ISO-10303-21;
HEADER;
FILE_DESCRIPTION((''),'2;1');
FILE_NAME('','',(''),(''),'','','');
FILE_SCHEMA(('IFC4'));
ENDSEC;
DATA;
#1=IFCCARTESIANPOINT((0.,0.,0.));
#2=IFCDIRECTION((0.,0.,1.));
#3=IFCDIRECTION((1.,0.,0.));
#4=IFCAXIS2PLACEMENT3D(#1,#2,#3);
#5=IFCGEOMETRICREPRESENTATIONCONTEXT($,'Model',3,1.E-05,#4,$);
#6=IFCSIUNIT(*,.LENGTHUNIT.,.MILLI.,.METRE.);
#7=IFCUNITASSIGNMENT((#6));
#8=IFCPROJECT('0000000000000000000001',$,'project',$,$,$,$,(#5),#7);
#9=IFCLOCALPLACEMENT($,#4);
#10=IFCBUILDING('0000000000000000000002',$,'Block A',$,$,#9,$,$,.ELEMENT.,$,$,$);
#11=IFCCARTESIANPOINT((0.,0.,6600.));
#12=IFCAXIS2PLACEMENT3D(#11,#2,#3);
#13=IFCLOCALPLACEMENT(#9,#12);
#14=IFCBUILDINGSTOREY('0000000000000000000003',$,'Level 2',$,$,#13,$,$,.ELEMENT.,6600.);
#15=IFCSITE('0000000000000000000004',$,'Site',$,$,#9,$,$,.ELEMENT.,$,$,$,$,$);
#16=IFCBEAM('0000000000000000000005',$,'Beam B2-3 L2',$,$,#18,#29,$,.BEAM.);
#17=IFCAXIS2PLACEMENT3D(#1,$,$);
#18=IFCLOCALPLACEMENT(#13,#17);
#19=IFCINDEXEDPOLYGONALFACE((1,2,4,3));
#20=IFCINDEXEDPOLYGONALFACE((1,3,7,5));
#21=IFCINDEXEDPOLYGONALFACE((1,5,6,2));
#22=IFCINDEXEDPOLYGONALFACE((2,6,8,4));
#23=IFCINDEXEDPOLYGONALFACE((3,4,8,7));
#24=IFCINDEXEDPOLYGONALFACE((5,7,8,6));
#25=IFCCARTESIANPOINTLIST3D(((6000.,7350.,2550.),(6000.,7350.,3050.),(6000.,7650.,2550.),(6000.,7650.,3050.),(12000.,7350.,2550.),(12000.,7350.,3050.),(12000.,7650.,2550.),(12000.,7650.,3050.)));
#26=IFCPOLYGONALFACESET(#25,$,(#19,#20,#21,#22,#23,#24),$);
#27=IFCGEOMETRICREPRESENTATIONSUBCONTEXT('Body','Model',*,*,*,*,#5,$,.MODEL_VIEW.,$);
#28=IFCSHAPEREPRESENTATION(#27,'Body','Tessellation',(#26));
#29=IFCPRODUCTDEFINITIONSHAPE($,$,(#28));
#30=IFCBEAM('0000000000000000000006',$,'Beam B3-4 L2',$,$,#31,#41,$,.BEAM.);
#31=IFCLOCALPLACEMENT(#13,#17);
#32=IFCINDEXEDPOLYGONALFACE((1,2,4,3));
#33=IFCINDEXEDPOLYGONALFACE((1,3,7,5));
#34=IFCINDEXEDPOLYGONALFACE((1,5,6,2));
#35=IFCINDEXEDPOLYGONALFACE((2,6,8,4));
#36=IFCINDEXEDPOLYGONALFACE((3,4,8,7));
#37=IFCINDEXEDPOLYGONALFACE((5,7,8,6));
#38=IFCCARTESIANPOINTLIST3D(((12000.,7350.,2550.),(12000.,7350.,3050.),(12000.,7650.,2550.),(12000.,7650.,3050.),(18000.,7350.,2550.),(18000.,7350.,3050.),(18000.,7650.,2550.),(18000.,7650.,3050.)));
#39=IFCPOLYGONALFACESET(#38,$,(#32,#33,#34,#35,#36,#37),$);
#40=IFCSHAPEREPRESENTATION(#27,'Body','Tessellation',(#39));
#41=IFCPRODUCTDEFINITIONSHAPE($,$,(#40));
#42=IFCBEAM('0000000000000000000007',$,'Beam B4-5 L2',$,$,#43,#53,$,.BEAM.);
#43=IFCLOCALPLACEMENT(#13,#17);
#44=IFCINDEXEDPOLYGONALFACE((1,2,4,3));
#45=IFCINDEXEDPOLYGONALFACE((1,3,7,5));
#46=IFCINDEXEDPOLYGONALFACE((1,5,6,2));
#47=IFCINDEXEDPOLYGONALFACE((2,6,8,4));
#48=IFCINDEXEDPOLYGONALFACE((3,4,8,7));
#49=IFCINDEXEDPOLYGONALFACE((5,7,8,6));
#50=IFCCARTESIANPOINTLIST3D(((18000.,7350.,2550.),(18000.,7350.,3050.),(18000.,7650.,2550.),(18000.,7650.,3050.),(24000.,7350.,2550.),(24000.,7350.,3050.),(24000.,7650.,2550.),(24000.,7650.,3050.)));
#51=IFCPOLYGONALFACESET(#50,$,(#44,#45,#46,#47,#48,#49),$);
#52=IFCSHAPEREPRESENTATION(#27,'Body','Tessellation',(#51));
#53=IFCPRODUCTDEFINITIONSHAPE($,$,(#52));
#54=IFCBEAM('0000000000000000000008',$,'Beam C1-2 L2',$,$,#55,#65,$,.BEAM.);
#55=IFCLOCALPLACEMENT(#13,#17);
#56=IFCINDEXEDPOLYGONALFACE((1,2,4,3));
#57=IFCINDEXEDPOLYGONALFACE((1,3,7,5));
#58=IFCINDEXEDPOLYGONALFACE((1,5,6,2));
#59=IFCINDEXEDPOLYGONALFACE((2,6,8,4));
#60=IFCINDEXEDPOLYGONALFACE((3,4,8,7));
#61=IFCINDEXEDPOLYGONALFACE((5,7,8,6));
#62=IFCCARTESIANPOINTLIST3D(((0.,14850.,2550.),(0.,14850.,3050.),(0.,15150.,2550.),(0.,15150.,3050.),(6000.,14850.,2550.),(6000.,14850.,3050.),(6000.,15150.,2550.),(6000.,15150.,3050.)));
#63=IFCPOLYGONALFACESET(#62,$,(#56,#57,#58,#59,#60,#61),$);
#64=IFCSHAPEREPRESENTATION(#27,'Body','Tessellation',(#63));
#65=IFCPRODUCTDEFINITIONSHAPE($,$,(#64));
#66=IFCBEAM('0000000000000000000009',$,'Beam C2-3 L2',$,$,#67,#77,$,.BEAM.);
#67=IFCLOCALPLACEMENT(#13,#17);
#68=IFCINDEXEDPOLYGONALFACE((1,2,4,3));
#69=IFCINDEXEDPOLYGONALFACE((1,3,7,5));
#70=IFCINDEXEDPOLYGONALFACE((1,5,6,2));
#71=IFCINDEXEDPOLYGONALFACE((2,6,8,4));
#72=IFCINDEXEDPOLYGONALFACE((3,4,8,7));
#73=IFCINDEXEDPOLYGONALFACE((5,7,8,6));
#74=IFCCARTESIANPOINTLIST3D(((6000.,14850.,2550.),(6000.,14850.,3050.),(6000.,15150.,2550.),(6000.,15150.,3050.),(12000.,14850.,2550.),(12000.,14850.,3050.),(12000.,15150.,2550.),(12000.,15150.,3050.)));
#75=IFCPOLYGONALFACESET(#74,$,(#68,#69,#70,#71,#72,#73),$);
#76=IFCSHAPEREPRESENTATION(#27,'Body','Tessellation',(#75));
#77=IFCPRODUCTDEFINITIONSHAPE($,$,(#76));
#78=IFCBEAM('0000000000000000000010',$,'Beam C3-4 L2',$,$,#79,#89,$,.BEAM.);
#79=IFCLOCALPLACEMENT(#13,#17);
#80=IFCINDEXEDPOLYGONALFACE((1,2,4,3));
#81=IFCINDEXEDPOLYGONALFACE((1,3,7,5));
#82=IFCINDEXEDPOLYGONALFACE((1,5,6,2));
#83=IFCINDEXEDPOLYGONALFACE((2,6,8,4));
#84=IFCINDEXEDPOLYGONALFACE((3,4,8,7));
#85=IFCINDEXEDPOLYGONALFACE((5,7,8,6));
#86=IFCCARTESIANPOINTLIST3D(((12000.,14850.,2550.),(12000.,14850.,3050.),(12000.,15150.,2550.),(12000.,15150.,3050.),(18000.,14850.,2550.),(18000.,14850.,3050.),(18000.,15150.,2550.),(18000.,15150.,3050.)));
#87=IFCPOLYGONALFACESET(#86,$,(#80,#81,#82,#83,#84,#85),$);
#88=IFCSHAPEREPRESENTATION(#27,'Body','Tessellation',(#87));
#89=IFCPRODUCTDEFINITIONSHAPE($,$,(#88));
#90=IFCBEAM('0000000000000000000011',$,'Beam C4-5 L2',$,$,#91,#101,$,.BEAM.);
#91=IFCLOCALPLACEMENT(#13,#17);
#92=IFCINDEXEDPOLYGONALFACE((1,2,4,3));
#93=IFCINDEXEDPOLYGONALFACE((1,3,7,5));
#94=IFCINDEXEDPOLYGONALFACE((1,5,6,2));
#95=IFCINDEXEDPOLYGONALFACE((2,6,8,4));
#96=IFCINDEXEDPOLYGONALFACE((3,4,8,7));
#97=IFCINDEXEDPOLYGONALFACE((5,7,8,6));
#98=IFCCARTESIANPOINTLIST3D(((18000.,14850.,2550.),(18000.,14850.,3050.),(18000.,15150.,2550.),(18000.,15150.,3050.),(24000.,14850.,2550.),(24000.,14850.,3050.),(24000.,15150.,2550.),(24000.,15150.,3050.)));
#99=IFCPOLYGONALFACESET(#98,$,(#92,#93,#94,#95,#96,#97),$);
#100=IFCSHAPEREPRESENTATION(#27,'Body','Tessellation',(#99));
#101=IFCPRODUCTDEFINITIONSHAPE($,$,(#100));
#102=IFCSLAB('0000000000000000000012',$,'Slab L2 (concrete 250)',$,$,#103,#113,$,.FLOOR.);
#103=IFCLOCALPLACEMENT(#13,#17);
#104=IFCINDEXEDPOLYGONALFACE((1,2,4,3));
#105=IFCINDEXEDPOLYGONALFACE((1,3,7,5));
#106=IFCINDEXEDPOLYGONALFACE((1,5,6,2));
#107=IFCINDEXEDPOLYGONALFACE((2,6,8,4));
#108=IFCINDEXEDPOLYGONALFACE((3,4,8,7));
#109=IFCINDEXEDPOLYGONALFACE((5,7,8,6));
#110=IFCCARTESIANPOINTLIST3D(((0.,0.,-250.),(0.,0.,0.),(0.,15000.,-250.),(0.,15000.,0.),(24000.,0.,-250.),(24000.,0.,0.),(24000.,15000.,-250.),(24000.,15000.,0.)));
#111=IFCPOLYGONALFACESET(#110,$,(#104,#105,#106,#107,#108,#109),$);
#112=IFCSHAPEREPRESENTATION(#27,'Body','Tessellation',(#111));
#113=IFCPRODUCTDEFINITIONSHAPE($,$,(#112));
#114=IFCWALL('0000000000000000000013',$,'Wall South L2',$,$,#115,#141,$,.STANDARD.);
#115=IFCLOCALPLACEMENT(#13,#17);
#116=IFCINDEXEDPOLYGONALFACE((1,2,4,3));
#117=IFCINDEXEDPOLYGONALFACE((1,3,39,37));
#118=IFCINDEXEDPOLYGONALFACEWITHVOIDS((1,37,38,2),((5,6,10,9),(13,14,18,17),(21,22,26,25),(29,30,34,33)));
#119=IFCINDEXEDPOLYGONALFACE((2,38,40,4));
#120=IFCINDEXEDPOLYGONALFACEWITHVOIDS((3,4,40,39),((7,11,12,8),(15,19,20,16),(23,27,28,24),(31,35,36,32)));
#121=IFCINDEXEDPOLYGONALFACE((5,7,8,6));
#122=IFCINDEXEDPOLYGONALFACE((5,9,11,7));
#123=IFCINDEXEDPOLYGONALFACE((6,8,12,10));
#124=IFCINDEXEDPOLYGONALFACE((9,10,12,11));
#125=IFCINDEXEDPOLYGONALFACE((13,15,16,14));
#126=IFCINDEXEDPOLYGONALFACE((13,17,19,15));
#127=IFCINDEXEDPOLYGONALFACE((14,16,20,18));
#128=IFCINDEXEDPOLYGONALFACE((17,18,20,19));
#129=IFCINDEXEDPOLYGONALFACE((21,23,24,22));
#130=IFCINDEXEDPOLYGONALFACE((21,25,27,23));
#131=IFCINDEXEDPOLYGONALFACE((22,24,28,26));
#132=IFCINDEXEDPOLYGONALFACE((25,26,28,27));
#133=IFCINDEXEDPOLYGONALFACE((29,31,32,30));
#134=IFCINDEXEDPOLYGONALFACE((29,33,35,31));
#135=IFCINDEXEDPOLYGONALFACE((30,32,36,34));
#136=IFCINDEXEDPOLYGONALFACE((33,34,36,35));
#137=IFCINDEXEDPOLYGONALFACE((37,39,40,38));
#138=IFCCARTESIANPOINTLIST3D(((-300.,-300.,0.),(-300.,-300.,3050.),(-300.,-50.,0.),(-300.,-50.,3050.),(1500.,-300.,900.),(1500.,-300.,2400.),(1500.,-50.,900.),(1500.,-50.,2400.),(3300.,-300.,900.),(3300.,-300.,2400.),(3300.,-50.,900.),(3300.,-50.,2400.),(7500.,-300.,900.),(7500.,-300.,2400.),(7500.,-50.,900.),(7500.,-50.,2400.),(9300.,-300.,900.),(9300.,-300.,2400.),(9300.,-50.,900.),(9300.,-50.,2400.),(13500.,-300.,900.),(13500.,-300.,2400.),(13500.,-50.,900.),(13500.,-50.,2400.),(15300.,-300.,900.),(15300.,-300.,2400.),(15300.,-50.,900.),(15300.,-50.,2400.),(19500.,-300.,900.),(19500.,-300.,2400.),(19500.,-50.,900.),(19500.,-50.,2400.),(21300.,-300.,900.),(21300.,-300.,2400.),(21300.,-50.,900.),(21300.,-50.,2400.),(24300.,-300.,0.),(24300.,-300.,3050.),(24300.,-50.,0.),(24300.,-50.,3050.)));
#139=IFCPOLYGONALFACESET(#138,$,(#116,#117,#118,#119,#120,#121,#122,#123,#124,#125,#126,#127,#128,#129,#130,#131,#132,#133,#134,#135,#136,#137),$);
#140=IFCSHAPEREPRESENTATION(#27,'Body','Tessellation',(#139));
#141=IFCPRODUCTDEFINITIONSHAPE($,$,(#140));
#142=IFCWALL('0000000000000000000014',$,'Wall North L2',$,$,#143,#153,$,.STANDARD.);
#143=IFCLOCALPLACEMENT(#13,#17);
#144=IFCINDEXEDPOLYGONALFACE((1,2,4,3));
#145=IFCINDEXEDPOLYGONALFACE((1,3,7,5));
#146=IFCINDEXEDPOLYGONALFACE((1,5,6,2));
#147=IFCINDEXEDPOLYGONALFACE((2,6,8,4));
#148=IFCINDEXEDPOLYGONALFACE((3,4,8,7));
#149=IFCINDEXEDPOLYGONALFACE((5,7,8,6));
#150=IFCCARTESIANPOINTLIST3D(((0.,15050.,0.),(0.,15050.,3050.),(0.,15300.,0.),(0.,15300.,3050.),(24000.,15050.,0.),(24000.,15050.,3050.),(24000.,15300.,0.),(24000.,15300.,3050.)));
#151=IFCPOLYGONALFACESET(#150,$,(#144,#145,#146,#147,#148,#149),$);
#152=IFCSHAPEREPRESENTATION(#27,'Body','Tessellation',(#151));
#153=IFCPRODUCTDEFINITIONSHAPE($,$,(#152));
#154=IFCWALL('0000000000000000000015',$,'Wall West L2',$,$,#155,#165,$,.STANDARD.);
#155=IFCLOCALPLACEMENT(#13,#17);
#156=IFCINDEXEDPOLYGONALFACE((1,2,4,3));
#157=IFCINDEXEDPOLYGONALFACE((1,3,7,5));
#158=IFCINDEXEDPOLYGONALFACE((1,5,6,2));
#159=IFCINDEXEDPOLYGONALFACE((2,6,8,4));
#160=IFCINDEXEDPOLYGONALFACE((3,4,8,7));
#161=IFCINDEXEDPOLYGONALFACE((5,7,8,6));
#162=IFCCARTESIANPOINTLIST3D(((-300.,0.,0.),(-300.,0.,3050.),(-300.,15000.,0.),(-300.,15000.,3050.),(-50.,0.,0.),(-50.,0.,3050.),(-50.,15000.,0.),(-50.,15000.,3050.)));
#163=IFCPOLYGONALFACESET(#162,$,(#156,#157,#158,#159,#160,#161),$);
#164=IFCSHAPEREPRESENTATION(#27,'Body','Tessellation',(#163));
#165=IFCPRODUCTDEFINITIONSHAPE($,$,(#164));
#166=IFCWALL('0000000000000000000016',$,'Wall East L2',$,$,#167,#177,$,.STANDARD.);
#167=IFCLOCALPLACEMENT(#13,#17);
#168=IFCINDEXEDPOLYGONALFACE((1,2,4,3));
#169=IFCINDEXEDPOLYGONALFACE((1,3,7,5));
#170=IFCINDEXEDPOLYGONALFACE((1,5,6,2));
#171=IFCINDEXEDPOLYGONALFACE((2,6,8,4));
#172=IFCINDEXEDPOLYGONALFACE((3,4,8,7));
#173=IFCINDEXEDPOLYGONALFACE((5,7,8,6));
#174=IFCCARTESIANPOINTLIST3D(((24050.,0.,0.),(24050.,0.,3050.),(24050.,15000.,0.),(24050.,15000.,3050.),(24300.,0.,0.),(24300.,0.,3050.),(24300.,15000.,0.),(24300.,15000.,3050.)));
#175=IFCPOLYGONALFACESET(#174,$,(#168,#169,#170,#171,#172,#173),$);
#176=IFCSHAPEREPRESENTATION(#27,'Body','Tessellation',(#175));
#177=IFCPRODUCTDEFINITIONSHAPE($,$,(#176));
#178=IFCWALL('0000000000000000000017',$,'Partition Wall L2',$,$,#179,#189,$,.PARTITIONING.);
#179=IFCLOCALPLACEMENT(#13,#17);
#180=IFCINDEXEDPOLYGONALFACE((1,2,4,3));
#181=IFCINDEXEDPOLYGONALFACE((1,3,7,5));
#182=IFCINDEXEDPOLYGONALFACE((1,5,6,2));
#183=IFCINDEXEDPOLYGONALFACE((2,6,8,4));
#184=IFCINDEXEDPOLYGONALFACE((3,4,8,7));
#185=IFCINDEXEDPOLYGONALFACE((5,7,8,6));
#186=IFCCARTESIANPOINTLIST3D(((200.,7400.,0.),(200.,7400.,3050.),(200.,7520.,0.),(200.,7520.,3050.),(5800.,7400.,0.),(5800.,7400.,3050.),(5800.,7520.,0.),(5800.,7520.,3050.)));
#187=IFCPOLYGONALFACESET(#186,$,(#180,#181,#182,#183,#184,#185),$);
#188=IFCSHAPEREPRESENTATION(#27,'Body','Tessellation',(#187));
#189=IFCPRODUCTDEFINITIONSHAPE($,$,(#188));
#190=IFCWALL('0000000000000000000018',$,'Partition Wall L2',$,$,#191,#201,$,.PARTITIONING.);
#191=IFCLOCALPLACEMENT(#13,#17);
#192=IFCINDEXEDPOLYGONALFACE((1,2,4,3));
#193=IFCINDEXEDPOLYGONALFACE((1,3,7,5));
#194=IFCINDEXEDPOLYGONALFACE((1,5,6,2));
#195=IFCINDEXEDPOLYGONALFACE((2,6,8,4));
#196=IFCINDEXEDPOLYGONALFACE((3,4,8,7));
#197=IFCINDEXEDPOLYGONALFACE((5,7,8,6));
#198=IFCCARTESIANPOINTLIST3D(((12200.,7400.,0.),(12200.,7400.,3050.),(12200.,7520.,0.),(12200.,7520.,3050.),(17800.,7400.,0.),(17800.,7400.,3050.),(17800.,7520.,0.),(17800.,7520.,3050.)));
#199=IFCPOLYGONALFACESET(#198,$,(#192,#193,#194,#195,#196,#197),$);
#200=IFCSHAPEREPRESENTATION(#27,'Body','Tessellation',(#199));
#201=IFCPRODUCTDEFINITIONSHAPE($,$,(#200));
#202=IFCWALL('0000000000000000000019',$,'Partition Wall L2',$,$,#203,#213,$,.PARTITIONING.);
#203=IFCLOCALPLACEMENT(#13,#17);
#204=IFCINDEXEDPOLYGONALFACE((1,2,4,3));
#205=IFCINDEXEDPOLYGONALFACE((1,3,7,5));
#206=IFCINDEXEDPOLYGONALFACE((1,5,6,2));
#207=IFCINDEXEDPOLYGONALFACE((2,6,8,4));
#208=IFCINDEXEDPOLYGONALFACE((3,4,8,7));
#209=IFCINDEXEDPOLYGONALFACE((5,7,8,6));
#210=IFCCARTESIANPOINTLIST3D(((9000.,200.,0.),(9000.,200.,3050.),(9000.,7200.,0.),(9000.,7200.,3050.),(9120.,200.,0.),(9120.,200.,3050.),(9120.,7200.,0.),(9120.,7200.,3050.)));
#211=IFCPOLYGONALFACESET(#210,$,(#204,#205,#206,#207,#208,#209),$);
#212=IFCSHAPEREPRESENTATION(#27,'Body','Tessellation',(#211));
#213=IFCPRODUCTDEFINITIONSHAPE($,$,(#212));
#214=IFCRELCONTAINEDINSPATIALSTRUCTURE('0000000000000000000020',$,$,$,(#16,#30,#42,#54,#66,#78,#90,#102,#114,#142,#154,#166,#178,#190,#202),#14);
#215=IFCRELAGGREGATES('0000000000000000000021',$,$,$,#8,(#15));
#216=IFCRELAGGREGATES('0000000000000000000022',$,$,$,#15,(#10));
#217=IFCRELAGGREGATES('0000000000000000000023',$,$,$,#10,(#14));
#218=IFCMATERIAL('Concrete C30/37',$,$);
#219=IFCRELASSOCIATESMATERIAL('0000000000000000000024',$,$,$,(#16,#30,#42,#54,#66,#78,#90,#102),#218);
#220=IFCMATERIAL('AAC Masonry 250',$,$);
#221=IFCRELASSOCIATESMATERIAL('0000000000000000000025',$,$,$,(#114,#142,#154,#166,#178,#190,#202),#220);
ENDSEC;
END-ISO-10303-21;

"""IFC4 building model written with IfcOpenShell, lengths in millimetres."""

from ifc_helpers import new_model, si_unit, frame, frame_2d, origin_with_axes, place, context, subcontext, project, spatial, polyline, rectangle, outline, extrude, material, element, save


model = new_model("IFC4")

# Units and contexts
model_context = context("Model", 3, precision=1e-05, world=origin_with_axes())
body_context = subcontext(model_context, "Body", "Model", "MODEL_VIEW")
ifc_project = project(units=[si_unit("LENGTHUNIT", "METRE", prefix="MILLI")], contexts=[model_context])

# Site, building, storey
placement = place(None, origin_with_axes())
site = spatial("IfcSite", under=ifc_project, at=placement, Name="Site", CompositionType="ELEMENT")
building = spatial("IfcBuilding", under=site, at=placement, Name="Block A", CompositionType="ELEMENT")
storey_placement = place(placement, frame((0.0, 0.0, 6600.0), z_axis=(0.0, 0.0, 1.0), x_axis=(1.0, 0.0, 0.0)))
storey = spatial("IfcBuildingStorey", under=building, at=storey_placement, Name="Level 2", CompositionType="ELEMENT", Elevation=6600.0)

# Shared definitions
ifc_material_1 = material(Name="Concrete C30/37")

# Beams
for number, where, z_axis, x_axis, name in (
    (1, (6000.0, 7500.0, 9150.0), (0.0, 0.0, 1.0), (1.0, 0.0, 0.0), "Beam B2-3 L2"),
    (2, (12000.0, 7500.0, 9150.0), (0.0, 0.0, 1.0), (1.0, 0.0, 0.0), "Beam B3-4 L2"),
    (3, (18000.0, 7500.0, 9150.0), (0.0, 0.0, 1.0), (1.0, 0.0, 0.0), "Beam B4-5 L2"),
    (4, (0.0, 15000.0, 9150.0), (0.0, 0.0, 1.0), (1.0, 0.0, 0.0), "Beam C1-2 L2"),
    (5, (6000.0, 15000.0, 9150.0), (0.0, 0.0, 1.0), (1.0, 0.0, 0.0), "Beam C2-3 L2"),
    (6, (12000.0, 15000.0, 9150.0), (0.0, 0.0, 1.0), (1.0, 0.0, 0.0), "Beam C3-4 L2"),
    (7, (18000.0, 15000.0, 9150.0), (0.0, 0.0, 1.0), (1.0, 0.0, 0.0), "Beam C4-5 L2"),
):
    element("IfcBeam", number, at=place(placement, frame(where, z_axis=z_axis, x_axis=x_axis)), inside=storey, material=ifc_material_1, Name=name, PredefinedType="BEAM", context=body_context, shape_type="SweptSolid", body=[
        extrude(rectangle(XDim=6000.0, YDim=300.0, at=frame_2d((3000.0, 0.0))), origin_with_axes(), (0.0, 0.0, 1.0), 500.0),
    ])

# Slab
slab_placement = place(placement, frame((0.0, 0.0, 6350.0), z_axis=(0.0, 0.0, 1.0), x_axis=(1.0, 0.0, 0.0)))
element("IfcSlab", 8, at=slab_placement, inside=storey, material=ifc_material_1, Name="Slab L2 (concrete 250)", PredefinedType="FLOOR", context=body_context, shape_type="SweptSolid", body=[
    extrude(rectangle(XDim=24000.0, YDim=15000.0, at=frame_2d((12000.0, 7500.0))), origin_with_axes(), (0.0, 0.0, 1.0), 250.0),
])

# Walls
ifc_material_2 = material(Name="AAC Masonry 250")
wall_1_placement = place(placement, frame((0.0, 0.0, 6600.0), z_axis=(0.0, 0.0, 1.0), x_axis=(1.0, 0.0, 0.0)))
element("IfcWall", 9, at=wall_1_placement, inside=storey, material=ifc_material_2, Name="Wall South L2", PredefinedType="STANDARD", context=body_context, shape_type="SweptSolid", body=[
    extrude(outline(polyline([(-300.0, 0.0), (24300.0, 0.0), (24300.0, 3050.0), (-300.0, 3050.0), (-300.0, 0.0)]), holes=[polyline([(1500.0, 900.0), (3300.0, 900.0), (3300.0, 2400.0), (1500.0, 2400.0), (1500.0, 900.0)]), polyline([(7500.0, 900.0), (9300.0, 900.0), (9300.0, 2400.0), (7500.0, 2400.0), (7500.0, 900.0)]), polyline([(13500.0, 900.0), (15300.0, 900.0), (15300.0, 2400.0), (13500.0, 2400.0), (13500.0, 900.0)]), polyline([(19500.0, 900.0), (21300.0, 900.0), (21300.0, 2400.0), (19500.0, 2400.0), (19500.0, 900.0)])]), frame((0.0, -50.0, 0.0), z_axis=(0.0, -1.0, 0.0), x_axis=(1.0, 0.0, 0.0)), (0.0, 0.0, 1.0), 250.0),
])
wall_2_placement = place(placement, frame((0.0, 15050.0, 6600.0), z_axis=(0.0, 0.0, 1.0), x_axis=(1.0, 0.0, 0.0)))
element("IfcWall", 10, at=wall_2_placement, inside=storey, material=ifc_material_2, Name="Wall North L2", PredefinedType="STANDARD", context=body_context, shape_type="SweptSolid", body=[
    extrude(rectangle(XDim=24000.0, YDim=250.0, at=frame_2d((12000.0, 125.0))), origin_with_axes(), (0.0, 0.0, 1.0), 3050.0),
])
for number, where, z_axis, x_axis, name in (
    (11, (-300.0, 0.0, 6600.0), (0.0, 0.0, 1.0), (1.0, 0.0, 0.0), "Wall West L2"),
    (12, (24050.0, 0.0, 6600.0), (0.0, 0.0, 1.0), (1.0, 0.0, 0.0), "Wall East L2"),
):
    element("IfcWall", number, at=place(placement, frame(where, z_axis=z_axis, x_axis=x_axis)), inside=storey, material=ifc_material_2, Name=name, PredefinedType="STANDARD", context=body_context, shape_type="SweptSolid", body=[
        extrude(rectangle(XDim=250.0, YDim=15000.0, at=frame_2d((125.0, 7500.0))), origin_with_axes(), (0.0, 0.0, 1.0), 3050.0),
    ])
for number, where, z_axis, x_axis, name in (
    (13, (200.0, 7400.0, 6600.0), (0.0, 0.0, 1.0), (1.0, 0.0, 0.0), "Partition Wall L2"),
    (14, (12200.0, 7400.0, 6600.0), (0.0, 0.0, 1.0), (1.0, 0.0, 0.0), "Partition Wall L2"),
):
    element("IfcWall", number, at=place(placement, frame(where, z_axis=z_axis, x_axis=x_axis)), inside=storey, material=ifc_material_2, Name=name, PredefinedType="PARTITIONING", context=body_context, shape_type="SweptSolid", body=[
        extrude(rectangle(XDim=5600.0, YDim=120.0, at=frame_2d((2800.0, 60.0))), origin_with_axes(), (0.0, 0.0, 1.0), 3050.0),
    ])
wall_3_placement = place(placement, frame((9000.0, 200.0, 6600.0), z_axis=(0.0, 0.0, 1.0), x_axis=(1.0, 0.0, 0.0)))
element("IfcWall", 15, at=wall_3_placement, inside=storey, material=ifc_material_2, Name="Partition Wall L2", PredefinedType="PARTITIONING", context=body_context, shape_type="SweptSolid", body=[
    extrude(rectangle(XDim=120.0, YDim=7000.0, at=frame_2d((60.0, 3500.0))), origin_with_axes(), (0.0, 0.0, 1.0), 3050.0),
])

save(model, "model.ifc")
